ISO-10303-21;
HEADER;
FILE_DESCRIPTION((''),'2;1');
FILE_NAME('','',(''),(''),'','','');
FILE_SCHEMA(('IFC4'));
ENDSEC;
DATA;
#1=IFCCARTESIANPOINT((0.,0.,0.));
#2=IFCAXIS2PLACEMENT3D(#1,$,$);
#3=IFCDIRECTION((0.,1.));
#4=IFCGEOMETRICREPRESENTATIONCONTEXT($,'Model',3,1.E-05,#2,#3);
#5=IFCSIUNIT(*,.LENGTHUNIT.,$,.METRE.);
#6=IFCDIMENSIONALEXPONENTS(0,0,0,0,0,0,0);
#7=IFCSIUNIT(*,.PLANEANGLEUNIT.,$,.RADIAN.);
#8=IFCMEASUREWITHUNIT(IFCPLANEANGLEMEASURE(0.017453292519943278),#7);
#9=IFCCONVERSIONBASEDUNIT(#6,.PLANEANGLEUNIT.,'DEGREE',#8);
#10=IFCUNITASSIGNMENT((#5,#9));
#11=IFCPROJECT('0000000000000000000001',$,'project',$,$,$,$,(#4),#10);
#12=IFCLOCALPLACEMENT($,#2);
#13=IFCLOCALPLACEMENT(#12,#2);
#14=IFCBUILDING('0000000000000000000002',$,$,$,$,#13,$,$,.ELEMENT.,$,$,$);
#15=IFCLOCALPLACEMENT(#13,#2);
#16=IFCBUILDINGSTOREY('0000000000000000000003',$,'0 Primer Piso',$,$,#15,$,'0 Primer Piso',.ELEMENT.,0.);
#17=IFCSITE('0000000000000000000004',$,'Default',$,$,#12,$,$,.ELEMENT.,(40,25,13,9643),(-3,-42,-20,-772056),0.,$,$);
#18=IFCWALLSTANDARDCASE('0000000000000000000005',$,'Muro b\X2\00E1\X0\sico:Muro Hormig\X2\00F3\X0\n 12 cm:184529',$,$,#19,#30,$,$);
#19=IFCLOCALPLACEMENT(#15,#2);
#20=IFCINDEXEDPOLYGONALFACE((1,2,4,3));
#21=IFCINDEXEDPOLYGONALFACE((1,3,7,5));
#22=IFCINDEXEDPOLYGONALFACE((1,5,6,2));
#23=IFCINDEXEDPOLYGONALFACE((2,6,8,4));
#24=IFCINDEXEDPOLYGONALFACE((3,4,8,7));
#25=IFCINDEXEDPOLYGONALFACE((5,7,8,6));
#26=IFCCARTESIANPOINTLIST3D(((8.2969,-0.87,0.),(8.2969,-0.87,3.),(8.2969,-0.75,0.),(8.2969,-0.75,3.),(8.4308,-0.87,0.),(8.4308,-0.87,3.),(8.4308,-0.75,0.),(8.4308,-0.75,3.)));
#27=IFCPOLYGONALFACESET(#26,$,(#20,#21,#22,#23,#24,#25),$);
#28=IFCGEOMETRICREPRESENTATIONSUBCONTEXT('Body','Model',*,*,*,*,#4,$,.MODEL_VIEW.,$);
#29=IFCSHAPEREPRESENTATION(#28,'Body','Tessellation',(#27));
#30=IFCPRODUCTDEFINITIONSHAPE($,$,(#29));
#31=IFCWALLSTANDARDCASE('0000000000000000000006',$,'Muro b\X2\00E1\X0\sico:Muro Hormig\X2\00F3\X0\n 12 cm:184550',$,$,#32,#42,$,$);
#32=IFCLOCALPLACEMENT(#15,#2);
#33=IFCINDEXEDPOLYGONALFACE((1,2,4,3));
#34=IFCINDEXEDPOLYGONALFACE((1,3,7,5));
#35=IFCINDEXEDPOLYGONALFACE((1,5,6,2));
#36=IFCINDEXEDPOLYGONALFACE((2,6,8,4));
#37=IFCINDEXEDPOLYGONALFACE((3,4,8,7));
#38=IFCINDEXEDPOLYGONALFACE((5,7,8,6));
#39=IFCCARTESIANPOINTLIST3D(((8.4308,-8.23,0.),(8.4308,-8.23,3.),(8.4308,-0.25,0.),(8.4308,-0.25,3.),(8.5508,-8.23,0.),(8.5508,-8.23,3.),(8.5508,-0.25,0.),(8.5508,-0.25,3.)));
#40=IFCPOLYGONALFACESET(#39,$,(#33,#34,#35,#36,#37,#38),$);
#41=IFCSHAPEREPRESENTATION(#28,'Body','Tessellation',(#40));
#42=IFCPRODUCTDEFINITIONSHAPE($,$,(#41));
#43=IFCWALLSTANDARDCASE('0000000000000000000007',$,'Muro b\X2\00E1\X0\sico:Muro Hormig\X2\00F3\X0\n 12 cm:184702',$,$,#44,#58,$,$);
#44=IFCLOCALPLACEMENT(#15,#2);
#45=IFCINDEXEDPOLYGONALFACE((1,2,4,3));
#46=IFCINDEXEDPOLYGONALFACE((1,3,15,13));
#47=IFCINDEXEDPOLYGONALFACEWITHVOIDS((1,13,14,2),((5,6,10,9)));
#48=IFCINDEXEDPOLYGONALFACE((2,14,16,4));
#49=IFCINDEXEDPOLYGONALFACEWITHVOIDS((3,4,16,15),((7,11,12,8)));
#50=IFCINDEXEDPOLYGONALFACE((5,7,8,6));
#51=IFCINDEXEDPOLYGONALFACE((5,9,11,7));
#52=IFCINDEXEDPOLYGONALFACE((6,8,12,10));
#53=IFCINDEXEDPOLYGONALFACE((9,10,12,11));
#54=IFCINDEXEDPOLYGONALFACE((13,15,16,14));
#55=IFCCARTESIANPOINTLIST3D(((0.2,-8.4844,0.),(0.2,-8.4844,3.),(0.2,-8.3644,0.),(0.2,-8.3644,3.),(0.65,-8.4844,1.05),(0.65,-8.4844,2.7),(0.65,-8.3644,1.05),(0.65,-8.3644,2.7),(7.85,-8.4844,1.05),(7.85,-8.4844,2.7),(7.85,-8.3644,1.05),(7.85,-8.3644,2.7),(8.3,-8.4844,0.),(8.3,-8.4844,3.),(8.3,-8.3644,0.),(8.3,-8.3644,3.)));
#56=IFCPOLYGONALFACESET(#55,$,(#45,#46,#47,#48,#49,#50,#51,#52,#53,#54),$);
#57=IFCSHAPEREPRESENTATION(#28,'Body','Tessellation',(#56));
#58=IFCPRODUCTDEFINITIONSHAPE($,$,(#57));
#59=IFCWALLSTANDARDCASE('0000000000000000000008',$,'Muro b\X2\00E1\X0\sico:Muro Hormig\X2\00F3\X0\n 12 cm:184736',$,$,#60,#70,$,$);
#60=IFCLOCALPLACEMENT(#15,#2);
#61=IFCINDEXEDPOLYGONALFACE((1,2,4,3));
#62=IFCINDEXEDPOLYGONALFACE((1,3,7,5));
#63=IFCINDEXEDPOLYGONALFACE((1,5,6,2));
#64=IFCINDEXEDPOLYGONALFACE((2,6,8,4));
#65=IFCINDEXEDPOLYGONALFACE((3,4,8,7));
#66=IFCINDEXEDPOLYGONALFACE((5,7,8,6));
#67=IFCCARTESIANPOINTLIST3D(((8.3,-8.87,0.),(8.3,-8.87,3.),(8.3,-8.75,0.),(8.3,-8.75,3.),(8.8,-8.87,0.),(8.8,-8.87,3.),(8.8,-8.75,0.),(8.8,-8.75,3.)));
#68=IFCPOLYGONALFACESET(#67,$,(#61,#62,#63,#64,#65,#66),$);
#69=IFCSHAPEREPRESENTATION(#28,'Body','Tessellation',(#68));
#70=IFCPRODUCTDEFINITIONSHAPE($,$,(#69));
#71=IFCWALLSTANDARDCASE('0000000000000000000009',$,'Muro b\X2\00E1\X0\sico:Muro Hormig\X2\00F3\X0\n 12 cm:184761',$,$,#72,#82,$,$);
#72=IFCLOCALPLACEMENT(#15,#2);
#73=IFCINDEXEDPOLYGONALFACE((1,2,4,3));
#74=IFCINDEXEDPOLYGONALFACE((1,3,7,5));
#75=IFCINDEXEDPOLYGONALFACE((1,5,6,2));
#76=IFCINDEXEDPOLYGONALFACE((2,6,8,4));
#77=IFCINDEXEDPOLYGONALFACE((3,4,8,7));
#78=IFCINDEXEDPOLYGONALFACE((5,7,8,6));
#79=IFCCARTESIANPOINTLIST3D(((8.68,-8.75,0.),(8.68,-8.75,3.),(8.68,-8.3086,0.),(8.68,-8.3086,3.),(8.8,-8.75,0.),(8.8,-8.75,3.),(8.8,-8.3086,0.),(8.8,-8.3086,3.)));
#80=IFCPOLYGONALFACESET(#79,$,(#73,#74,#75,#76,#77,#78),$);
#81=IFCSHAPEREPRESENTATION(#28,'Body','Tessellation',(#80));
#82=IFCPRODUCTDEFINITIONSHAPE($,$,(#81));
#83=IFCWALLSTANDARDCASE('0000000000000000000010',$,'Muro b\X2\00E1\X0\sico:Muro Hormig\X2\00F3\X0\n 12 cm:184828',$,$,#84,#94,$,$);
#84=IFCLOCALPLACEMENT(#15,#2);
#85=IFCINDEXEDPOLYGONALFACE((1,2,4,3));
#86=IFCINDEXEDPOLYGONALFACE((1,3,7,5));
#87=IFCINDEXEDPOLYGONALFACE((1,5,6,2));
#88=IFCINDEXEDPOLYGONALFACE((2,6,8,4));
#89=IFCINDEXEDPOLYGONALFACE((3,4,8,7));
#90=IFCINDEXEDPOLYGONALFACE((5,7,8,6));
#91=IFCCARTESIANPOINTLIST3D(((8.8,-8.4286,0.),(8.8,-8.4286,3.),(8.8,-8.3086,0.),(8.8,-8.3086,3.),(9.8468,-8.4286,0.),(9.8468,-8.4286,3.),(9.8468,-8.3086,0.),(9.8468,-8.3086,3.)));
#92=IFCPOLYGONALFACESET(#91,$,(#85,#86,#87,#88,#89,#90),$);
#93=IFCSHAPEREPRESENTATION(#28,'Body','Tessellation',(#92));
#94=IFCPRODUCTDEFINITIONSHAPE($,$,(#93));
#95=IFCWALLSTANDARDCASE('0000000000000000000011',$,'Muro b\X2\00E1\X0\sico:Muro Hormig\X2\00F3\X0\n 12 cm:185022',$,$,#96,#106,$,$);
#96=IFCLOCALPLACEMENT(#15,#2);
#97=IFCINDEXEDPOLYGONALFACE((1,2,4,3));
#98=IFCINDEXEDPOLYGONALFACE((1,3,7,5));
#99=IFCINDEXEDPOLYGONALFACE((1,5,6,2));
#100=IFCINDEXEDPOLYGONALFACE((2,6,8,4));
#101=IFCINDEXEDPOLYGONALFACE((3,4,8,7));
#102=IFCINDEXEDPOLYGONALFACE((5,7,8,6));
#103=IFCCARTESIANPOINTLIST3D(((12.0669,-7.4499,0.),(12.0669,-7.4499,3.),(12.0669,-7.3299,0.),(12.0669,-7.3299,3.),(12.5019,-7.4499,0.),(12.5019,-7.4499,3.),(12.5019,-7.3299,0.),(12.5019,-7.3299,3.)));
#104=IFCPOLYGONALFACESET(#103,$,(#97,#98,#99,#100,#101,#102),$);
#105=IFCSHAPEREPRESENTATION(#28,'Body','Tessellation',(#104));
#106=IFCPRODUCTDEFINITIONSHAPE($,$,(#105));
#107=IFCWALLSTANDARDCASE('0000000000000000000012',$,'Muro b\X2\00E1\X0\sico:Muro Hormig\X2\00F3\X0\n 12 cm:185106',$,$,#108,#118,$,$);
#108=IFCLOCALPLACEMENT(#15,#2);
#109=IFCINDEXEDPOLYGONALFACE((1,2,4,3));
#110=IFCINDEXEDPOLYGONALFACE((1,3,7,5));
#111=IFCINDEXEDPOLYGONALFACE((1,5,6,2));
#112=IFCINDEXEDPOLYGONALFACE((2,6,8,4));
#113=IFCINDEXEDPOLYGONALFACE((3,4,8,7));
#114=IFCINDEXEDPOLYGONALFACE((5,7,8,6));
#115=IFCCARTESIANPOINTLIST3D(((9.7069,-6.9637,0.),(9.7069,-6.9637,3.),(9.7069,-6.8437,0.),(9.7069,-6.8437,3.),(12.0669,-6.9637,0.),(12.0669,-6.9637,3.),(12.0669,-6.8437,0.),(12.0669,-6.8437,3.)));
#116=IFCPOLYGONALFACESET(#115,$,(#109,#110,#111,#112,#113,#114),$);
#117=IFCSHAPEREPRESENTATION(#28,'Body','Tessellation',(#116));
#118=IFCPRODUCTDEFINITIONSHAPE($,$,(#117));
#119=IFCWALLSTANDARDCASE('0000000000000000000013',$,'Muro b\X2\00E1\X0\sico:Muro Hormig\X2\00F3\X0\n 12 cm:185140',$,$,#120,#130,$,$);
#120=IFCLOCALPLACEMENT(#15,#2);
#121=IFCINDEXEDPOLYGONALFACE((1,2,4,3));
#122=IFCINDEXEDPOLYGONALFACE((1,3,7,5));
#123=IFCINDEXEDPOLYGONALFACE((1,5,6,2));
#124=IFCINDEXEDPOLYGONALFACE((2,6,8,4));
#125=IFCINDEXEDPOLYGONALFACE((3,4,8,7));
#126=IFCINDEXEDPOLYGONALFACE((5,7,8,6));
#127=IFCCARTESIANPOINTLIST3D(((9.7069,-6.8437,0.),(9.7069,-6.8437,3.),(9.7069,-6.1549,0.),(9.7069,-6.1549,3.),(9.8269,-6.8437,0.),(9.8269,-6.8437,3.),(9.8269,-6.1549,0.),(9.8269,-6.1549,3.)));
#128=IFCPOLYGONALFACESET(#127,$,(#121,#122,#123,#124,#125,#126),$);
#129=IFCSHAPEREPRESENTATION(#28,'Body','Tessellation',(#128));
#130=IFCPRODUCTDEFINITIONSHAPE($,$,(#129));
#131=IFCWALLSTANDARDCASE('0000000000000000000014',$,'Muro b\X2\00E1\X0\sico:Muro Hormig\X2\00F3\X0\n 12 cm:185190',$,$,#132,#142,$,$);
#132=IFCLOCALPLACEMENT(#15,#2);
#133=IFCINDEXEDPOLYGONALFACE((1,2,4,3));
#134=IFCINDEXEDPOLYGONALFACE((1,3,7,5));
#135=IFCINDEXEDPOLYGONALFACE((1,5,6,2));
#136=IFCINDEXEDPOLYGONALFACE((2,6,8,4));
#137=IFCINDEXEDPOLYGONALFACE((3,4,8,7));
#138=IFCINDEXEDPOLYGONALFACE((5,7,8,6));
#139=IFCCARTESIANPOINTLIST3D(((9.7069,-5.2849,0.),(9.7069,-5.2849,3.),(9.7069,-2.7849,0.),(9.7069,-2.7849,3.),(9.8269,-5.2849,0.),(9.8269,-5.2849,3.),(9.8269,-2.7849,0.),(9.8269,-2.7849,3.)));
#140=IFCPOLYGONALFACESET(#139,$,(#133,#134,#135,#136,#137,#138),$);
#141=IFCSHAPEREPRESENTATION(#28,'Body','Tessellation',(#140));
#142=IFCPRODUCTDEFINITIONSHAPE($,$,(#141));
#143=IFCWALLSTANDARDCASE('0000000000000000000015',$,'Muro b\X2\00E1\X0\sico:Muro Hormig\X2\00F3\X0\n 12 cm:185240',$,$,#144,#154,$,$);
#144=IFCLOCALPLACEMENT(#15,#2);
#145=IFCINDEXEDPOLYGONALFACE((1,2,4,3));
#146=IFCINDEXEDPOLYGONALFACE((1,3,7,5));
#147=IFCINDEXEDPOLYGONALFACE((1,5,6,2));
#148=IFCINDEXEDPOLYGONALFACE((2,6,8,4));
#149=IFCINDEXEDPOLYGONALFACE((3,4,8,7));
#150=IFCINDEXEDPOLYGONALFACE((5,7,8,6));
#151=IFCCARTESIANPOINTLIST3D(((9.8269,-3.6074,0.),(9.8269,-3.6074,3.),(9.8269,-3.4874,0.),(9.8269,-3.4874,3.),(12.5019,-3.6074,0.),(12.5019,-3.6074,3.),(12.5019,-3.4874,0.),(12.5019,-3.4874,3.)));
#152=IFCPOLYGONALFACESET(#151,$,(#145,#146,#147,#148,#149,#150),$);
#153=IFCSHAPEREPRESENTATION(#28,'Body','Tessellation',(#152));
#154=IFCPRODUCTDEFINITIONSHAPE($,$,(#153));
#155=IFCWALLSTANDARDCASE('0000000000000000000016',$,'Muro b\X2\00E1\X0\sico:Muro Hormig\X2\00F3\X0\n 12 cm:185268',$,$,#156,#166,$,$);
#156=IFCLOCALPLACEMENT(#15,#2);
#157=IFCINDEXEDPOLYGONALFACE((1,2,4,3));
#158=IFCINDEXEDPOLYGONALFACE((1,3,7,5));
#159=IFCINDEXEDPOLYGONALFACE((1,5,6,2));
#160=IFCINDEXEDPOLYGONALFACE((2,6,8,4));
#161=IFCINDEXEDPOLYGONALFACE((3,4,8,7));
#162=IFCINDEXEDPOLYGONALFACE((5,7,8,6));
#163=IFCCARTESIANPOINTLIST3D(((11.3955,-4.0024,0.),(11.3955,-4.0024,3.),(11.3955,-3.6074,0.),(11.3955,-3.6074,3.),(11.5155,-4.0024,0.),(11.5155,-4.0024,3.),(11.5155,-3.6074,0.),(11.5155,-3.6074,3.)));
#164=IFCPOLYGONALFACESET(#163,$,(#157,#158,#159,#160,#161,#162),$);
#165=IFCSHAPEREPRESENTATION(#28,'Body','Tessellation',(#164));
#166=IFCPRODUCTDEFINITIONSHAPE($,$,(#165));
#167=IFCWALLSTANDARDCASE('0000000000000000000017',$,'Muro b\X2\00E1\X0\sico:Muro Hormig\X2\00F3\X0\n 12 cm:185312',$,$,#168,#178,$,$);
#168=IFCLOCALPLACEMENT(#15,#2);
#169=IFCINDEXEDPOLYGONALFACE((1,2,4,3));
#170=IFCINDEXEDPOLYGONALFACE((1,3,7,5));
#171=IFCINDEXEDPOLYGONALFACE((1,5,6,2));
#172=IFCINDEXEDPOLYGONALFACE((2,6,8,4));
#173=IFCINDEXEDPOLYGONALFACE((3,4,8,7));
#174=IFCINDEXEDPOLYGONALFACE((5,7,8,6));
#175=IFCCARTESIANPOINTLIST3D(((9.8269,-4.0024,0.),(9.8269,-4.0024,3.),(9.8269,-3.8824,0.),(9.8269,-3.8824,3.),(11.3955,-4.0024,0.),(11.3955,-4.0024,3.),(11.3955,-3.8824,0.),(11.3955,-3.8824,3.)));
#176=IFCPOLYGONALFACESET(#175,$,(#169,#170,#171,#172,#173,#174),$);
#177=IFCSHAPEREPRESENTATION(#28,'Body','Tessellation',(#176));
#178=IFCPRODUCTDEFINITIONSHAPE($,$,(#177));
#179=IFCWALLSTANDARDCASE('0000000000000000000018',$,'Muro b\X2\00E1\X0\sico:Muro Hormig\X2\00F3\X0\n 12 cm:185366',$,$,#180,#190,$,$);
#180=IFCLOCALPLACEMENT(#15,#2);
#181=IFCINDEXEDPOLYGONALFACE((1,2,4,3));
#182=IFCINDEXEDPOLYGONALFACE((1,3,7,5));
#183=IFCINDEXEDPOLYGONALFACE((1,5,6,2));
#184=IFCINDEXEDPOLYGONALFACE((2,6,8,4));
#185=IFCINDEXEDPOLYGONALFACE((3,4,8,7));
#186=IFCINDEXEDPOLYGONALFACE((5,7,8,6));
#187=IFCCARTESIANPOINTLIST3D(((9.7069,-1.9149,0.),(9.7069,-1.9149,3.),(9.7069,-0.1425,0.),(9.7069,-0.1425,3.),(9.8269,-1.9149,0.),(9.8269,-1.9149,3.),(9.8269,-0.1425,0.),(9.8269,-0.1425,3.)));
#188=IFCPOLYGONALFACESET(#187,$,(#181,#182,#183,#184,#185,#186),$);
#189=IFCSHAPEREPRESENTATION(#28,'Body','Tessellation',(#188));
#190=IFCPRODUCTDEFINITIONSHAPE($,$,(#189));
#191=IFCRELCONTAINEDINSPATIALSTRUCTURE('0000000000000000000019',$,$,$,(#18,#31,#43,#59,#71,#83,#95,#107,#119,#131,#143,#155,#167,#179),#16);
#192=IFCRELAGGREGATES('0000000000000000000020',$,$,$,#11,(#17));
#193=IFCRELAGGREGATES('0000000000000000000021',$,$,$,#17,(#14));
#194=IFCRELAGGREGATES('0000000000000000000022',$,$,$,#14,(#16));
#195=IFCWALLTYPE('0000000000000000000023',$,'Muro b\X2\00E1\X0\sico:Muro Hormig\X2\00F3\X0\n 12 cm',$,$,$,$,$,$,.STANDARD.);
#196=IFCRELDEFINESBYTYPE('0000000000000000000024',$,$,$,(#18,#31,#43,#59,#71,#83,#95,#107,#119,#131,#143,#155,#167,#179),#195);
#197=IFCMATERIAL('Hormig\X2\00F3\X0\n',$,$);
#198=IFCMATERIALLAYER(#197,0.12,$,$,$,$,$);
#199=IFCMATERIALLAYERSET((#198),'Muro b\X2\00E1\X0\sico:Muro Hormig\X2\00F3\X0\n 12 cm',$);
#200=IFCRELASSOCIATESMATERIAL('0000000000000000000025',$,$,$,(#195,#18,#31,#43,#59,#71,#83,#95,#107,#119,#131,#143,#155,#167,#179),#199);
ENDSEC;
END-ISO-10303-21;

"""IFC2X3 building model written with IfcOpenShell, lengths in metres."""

from ifc_helpers import new_model, entity, si_unit, converted_unit, direction, frame, frame_2d, origin, place, context, subcontext, project, spatial, rectangle, extrude, material, layer, layer_set, layer_usage, type_object, element, save


model = new_model("IFC2X3")

# Units and contexts
model_context = context("Model", 3, precision=1e-05, world=origin(), true_north=direction((0.0, 1.0)))
body_context = subcontext(model_context, "Body", "Model", "MODEL_VIEW")
ifc_project = project(units=[si_unit("LENGTHUNIT", "METRE"), converted_unit("PLANEANGLEUNIT", "DEGREE", entity("IfcPlaneAngleMeasure", 0.017453292519943278), si_unit("PLANEANGLEUNIT", "RADIAN"), dimensions=[0, 0, 0, 0, 0, 0, 0])], contexts=[model_context])

# Site, building, storey
site_placement = place(None, origin())
site = spatial("IfcSite", under=ifc_project, at=site_placement, Name="Default", CompositionType="ELEMENT", RefLatitude=(40, 25, 13, 9643), RefLongitude=(-3, -42, -20, -772056), RefElevation=0.0)
building_placement = place(site_placement, origin())
building = spatial("IfcBuilding", under=site, at=building_placement, CompositionType="ELEMENT")
storey_placement = place(building_placement, origin())
storey = spatial("IfcBuildingStorey", under=building, at=storey_placement, Name="0 Primer Piso", LongName="0 Primer Piso", CompositionType="ELEMENT", Elevation=0.0)

# Shared definitions
ifc_material = material(Name="Hormigón")
ifc_layer = layer(ifc_material, 0.12)
ifc_layer_set = layer_set([ifc_layer], Name="Muro básico:Muro Hormigón 12 cm")
wall_type = type_object("IfcWallType", Name="Muro básico:Muro Hormigón 12 cm", PredefinedType="STANDARD", material=ifc_layer_set)

# Walls
ifc_layer_usage_1 = layer_usage(ifc_layer_set, "AXIS2", "NEGATIVE", 0.06)
wall_1_placement = place(storey_placement, frame((8.2969, -0.81, 0.0)))
element("IfcWallStandardCase", 1, at=wall_1_placement, inside=storey, type_object=wall_type, material=ifc_layer_usage_1, Name="Muro básico:Muro Hormigón 12 cm:184529", context=body_context, shape_type="SweptSolid", body=[
    extrude(rectangle(XDim=0.134, YDim=0.12, at=frame_2d((0.067, 0.0), x_axis=(-1.0, 0.0))), origin(), (0.0, 0.0, 1.0), 3.0),
])
ifc_layer_usage_2 = layer_usage(ifc_layer_set, "AXIS2", "NEGATIVE", 0.06)
wall_2_placement = place(storey_placement, frame((8.4908, -8.23, 0.0), z_axis=(0.0, 0.0, 1.0), x_axis=(0.0, 1.0, 0.0)))
element("IfcWallStandardCase", 2, at=wall_2_placement, inside=storey, type_object=wall_type, material=ifc_layer_usage_2, Name="Muro básico:Muro Hormigón 12 cm:184550", context=body_context, shape_type="SweptSolid", body=[
    extrude(rectangle(XDim=7.98, YDim=0.12, at=frame_2d((3.99, 0.0), x_axis=(-1.0, 0.0))), origin(), (0.0, 0.0, 1.0), 3.0),
])

# Wall, opening
ifc_layer_usage_3 = layer_usage(ifc_layer_set, "AXIS2", "NEGATIVE", 0.06)
wall_3_placement = place(storey_placement, frame((0.2, -8.4244, 0.0)))
wall_3 = element("IfcWallStandardCase", 3, at=wall_3_placement, inside=storey, type_object=wall_type, material=ifc_layer_usage_3, Name="Muro básico:Muro Hormigón 12 cm:184702", context=body_context, shape_type="SweptSolid", body=[
    extrude(rectangle(XDim=8.1, YDim=0.12, at=frame_2d((4.05, 0.0), x_axis=(-1.0, 0.0))), origin(), (0.0, 0.0, 1.0), 3.0),
])
opening_1_placement = place(wall_3_placement, frame((0.45, -0.06, 1.05)))
element("IfcOpeningElement", 4, at=opening_1_placement, cuts=wall_3, ObjectType="Opening", context=body_context, shape_type="SweptSolid", body=[
    extrude(rectangle(XDim=1.65, YDim=7.2, at=frame_2d((0.825, 3.6), x_axis=(1.0, 0.0))), frame((0.0, 0.0, 0.0), z_axis=(0.0, 1.0, 0.0), x_axis=(0.0, 0.0, 1.0)), (0.0, 0.0, 1.0), 0.12),
])

# Walls
ifc_layer_usage_4 = layer_usage(ifc_layer_set, "AXIS2", "NEGATIVE", 0.06)
wall_4_placement = place(storey_placement, frame((8.3, -8.81, 0.0)))
element("IfcWallStandardCase", 5, at=wall_4_placement, inside=storey, type_object=wall_type, material=ifc_layer_usage_4, Name="Muro básico:Muro Hormigón 12 cm:184736", context=body_context, shape_type="SweptSolid", body=[
    extrude(rectangle(XDim=0.5, YDim=0.12, at=frame_2d((0.25, 0.0), x_axis=(-1.0, 0.0))), origin(), (0.0, 0.0, 1.0), 3.0),
])
ifc_layer_usage_5 = layer_usage(ifc_layer_set, "AXIS2", "NEGATIVE", 0.06)
wall_5_placement = place(storey_placement, frame((8.74, -8.75, 0.0), z_axis=(0.0, 0.0, 1.0), x_axis=(0.0, 1.0, 0.0)))
element("IfcWallStandardCase", 6, at=wall_5_placement, inside=storey, type_object=wall_type, material=ifc_layer_usage_5, Name="Muro básico:Muro Hormigón 12 cm:184761", context=body_context, shape_type="SweptSolid", body=[
    extrude(rectangle(XDim=0.4414, YDim=0.12, at=frame_2d((0.2207, 0.0), x_axis=(-1.0, 0.0))), origin(), (0.0, 0.0, 1.0), 3.0),
])
ifc_layer_usage_6 = layer_usage(ifc_layer_set, "AXIS2", "NEGATIVE", 0.06)
wall_6_placement = place(storey_placement, frame((8.8, -8.3686, 0.0)))
element("IfcWallStandardCase", 7, at=wall_6_placement, inside=storey, type_object=wall_type, material=ifc_layer_usage_6, Name="Muro básico:Muro Hormigón 12 cm:184828", context=body_context, shape_type="SweptSolid", body=[
    extrude(rectangle(XDim=1.0468, YDim=0.12, at=frame_2d((0.5234, 0.0), x_axis=(-1.0, 0.0))), origin(), (0.0, 0.0, 1.0), 3.0),
])
ifc_layer_usage_7 = layer_usage(ifc_layer_set, "AXIS2", "NEGATIVE", 0.06)
wall_7_placement = place(storey_placement, frame((12.5019, -7.3899, 0.0), z_axis=(0.0, 0.0, 1.0), x_axis=(-1.0, 0.0, 0.0)))
element("IfcWallStandardCase", 8, at=wall_7_placement, inside=storey, type_object=wall_type, material=ifc_layer_usage_7, Name="Muro básico:Muro Hormigón 12 cm:185022", context=body_context, shape_type="SweptSolid", body=[
    extrude(rectangle(XDim=0.4351, YDim=0.12, at=frame_2d((0.2175, 0.0), x_axis=(-1.0, 0.0))), origin(), (0.0, 0.0, 1.0), 3.0),
])
ifc_layer_usage_8 = layer_usage(ifc_layer_set, "AXIS2", "NEGATIVE", 0.06)
wall_8_placement = place(storey_placement, frame((12.0669, -6.9037, 0.0), z_axis=(0.0, 0.0, 1.0), x_axis=(-1.0, 0.0, 0.0)))
element("IfcWallStandardCase", 9, at=wall_8_placement, inside=storey, type_object=wall_type, material=ifc_layer_usage_8, Name="Muro básico:Muro Hormigón 12 cm:185106", context=body_context, shape_type="SweptSolid", body=[
    extrude(rectangle(XDim=2.36, YDim=0.12, at=frame_2d((1.18, 0.0), x_axis=(-1.0, 0.0))), origin(), (0.0, 0.0, 1.0), 3.0),
])
ifc_layer_usage_9 = layer_usage(ifc_layer_set, "AXIS2", "NEGATIVE", 0.06)
wall_9_placement = place(storey_placement, frame((9.7669, -6.8437, 0.0), z_axis=(0.0, 0.0, 1.0), x_axis=(0.0, 1.0, 0.0)))
element("IfcWallStandardCase", 10, at=wall_9_placement, inside=storey, type_object=wall_type, material=ifc_layer_usage_9, Name="Muro básico:Muro Hormigón 12 cm:185140", context=body_context, shape_type="SweptSolid", body=[
    extrude(rectangle(XDim=0.6888, YDim=0.12, at=frame_2d((0.3444, 0.0), x_axis=(-1.0, 0.0))), origin(), (0.0, 0.0, 1.0), 3.0),
])
ifc_layer_usage_10 = layer_usage(ifc_layer_set, "AXIS2", "NEGATIVE", 0.06)
wall_10_placement = place(storey_placement, frame((9.7669, -2.7849, 0.0), z_axis=(0.0, 0.0, 1.0), x_axis=(0.0, -1.0, 0.0)))
element("IfcWallStandardCase", 11, at=wall_10_placement, inside=storey, type_object=wall_type, material=ifc_layer_usage_10, Name="Muro básico:Muro Hormigón 12 cm:185190", context=body_context, shape_type="SweptSolid", body=[
    extrude(rectangle(XDim=2.5, YDim=0.12, at=frame_2d((1.25, 0.0), x_axis=(-1.0, 0.0))), origin(), (0.0, 0.0, 1.0), 3.0),
])
ifc_layer_usage_11 = layer_usage(ifc_layer_set, "AXIS2", "NEGATIVE", 0.06)
wall_11_placement = place(storey_placement, frame((9.8269, -3.5474, 0.0)))
element("IfcWallStandardCase", 12, at=wall_11_placement, inside=storey, type_object=wall_type, material=ifc_layer_usage_11, Name="Muro básico:Muro Hormigón 12 cm:185240", context=body_context, shape_type="SweptSolid", body=[
    extrude(rectangle(XDim=2.6751, YDim=0.12, at=frame_2d((1.3375, 0.0), x_axis=(-1.0, 0.0))), origin(), (0.0, 0.0, 1.0), 3.0),
])
ifc_layer_usage_12 = layer_usage(ifc_layer_set, "AXIS2", "NEGATIVE", 0.06)
wall_12_placement = place(storey_placement, frame((11.4555, -3.6074, 0.0), z_axis=(0.0, 0.0, 1.0), x_axis=(0.0, -1.0, 0.0)))
element("IfcWallStandardCase", 13, at=wall_12_placement, inside=storey, type_object=wall_type, material=ifc_layer_usage_12, Name="Muro básico:Muro Hormigón 12 cm:185268", context=body_context, shape_type="SweptSolid", body=[
    extrude(rectangle(XDim=0.395, YDim=0.12, at=frame_2d((0.1975, 0.0), x_axis=(-1.0, 0.0))), origin(), (0.0, 0.0, 1.0), 3.0),
])
ifc_layer_usage_13 = layer_usage(ifc_layer_set, "AXIS2", "NEGATIVE", 0.06)
wall_13_placement = place(storey_placement, frame((11.3955, -3.9424, 0.0), z_axis=(0.0, 0.0, 1.0), x_axis=(-1.0, 0.0, 0.0)))
element("IfcWallStandardCase", 14, at=wall_13_placement, inside=storey, type_object=wall_type, material=ifc_layer_usage_13, Name="Muro básico:Muro Hormigón 12 cm:185312", context=body_context, shape_type="SweptSolid", body=[
    extrude(rectangle(XDim=1.5686, YDim=0.12, at=frame_2d((0.7843, 0.0), x_axis=(-1.0, 0.0))), origin(), (0.0, 0.0, 1.0), 3.0),
])
ifc_layer_usage_14 = layer_usage(ifc_layer_set, "AXIS2", "NEGATIVE", 0.06)
wall_14_placement = place(storey_placement, frame((9.7669, -1.9149, 0.0), z_axis=(0.0, 0.0, 1.0), x_axis=(0.0, 1.0, 0.0)))
element("IfcWallStandardCase", 15, at=wall_14_placement, inside=storey, type_object=wall_type, material=ifc_layer_usage_14, Name="Muro básico:Muro Hormigón 12 cm:185366", context=body_context, shape_type="SweptSolid", body=[
    extrude(rectangle(XDim=1.7725, YDim=0.12, at=frame_2d((0.8862, 0.0), x_axis=(-1.0, 0.0))), origin(), (0.0, 0.0, 1.0), 3.0),
])

save(model, "model.ifc")
